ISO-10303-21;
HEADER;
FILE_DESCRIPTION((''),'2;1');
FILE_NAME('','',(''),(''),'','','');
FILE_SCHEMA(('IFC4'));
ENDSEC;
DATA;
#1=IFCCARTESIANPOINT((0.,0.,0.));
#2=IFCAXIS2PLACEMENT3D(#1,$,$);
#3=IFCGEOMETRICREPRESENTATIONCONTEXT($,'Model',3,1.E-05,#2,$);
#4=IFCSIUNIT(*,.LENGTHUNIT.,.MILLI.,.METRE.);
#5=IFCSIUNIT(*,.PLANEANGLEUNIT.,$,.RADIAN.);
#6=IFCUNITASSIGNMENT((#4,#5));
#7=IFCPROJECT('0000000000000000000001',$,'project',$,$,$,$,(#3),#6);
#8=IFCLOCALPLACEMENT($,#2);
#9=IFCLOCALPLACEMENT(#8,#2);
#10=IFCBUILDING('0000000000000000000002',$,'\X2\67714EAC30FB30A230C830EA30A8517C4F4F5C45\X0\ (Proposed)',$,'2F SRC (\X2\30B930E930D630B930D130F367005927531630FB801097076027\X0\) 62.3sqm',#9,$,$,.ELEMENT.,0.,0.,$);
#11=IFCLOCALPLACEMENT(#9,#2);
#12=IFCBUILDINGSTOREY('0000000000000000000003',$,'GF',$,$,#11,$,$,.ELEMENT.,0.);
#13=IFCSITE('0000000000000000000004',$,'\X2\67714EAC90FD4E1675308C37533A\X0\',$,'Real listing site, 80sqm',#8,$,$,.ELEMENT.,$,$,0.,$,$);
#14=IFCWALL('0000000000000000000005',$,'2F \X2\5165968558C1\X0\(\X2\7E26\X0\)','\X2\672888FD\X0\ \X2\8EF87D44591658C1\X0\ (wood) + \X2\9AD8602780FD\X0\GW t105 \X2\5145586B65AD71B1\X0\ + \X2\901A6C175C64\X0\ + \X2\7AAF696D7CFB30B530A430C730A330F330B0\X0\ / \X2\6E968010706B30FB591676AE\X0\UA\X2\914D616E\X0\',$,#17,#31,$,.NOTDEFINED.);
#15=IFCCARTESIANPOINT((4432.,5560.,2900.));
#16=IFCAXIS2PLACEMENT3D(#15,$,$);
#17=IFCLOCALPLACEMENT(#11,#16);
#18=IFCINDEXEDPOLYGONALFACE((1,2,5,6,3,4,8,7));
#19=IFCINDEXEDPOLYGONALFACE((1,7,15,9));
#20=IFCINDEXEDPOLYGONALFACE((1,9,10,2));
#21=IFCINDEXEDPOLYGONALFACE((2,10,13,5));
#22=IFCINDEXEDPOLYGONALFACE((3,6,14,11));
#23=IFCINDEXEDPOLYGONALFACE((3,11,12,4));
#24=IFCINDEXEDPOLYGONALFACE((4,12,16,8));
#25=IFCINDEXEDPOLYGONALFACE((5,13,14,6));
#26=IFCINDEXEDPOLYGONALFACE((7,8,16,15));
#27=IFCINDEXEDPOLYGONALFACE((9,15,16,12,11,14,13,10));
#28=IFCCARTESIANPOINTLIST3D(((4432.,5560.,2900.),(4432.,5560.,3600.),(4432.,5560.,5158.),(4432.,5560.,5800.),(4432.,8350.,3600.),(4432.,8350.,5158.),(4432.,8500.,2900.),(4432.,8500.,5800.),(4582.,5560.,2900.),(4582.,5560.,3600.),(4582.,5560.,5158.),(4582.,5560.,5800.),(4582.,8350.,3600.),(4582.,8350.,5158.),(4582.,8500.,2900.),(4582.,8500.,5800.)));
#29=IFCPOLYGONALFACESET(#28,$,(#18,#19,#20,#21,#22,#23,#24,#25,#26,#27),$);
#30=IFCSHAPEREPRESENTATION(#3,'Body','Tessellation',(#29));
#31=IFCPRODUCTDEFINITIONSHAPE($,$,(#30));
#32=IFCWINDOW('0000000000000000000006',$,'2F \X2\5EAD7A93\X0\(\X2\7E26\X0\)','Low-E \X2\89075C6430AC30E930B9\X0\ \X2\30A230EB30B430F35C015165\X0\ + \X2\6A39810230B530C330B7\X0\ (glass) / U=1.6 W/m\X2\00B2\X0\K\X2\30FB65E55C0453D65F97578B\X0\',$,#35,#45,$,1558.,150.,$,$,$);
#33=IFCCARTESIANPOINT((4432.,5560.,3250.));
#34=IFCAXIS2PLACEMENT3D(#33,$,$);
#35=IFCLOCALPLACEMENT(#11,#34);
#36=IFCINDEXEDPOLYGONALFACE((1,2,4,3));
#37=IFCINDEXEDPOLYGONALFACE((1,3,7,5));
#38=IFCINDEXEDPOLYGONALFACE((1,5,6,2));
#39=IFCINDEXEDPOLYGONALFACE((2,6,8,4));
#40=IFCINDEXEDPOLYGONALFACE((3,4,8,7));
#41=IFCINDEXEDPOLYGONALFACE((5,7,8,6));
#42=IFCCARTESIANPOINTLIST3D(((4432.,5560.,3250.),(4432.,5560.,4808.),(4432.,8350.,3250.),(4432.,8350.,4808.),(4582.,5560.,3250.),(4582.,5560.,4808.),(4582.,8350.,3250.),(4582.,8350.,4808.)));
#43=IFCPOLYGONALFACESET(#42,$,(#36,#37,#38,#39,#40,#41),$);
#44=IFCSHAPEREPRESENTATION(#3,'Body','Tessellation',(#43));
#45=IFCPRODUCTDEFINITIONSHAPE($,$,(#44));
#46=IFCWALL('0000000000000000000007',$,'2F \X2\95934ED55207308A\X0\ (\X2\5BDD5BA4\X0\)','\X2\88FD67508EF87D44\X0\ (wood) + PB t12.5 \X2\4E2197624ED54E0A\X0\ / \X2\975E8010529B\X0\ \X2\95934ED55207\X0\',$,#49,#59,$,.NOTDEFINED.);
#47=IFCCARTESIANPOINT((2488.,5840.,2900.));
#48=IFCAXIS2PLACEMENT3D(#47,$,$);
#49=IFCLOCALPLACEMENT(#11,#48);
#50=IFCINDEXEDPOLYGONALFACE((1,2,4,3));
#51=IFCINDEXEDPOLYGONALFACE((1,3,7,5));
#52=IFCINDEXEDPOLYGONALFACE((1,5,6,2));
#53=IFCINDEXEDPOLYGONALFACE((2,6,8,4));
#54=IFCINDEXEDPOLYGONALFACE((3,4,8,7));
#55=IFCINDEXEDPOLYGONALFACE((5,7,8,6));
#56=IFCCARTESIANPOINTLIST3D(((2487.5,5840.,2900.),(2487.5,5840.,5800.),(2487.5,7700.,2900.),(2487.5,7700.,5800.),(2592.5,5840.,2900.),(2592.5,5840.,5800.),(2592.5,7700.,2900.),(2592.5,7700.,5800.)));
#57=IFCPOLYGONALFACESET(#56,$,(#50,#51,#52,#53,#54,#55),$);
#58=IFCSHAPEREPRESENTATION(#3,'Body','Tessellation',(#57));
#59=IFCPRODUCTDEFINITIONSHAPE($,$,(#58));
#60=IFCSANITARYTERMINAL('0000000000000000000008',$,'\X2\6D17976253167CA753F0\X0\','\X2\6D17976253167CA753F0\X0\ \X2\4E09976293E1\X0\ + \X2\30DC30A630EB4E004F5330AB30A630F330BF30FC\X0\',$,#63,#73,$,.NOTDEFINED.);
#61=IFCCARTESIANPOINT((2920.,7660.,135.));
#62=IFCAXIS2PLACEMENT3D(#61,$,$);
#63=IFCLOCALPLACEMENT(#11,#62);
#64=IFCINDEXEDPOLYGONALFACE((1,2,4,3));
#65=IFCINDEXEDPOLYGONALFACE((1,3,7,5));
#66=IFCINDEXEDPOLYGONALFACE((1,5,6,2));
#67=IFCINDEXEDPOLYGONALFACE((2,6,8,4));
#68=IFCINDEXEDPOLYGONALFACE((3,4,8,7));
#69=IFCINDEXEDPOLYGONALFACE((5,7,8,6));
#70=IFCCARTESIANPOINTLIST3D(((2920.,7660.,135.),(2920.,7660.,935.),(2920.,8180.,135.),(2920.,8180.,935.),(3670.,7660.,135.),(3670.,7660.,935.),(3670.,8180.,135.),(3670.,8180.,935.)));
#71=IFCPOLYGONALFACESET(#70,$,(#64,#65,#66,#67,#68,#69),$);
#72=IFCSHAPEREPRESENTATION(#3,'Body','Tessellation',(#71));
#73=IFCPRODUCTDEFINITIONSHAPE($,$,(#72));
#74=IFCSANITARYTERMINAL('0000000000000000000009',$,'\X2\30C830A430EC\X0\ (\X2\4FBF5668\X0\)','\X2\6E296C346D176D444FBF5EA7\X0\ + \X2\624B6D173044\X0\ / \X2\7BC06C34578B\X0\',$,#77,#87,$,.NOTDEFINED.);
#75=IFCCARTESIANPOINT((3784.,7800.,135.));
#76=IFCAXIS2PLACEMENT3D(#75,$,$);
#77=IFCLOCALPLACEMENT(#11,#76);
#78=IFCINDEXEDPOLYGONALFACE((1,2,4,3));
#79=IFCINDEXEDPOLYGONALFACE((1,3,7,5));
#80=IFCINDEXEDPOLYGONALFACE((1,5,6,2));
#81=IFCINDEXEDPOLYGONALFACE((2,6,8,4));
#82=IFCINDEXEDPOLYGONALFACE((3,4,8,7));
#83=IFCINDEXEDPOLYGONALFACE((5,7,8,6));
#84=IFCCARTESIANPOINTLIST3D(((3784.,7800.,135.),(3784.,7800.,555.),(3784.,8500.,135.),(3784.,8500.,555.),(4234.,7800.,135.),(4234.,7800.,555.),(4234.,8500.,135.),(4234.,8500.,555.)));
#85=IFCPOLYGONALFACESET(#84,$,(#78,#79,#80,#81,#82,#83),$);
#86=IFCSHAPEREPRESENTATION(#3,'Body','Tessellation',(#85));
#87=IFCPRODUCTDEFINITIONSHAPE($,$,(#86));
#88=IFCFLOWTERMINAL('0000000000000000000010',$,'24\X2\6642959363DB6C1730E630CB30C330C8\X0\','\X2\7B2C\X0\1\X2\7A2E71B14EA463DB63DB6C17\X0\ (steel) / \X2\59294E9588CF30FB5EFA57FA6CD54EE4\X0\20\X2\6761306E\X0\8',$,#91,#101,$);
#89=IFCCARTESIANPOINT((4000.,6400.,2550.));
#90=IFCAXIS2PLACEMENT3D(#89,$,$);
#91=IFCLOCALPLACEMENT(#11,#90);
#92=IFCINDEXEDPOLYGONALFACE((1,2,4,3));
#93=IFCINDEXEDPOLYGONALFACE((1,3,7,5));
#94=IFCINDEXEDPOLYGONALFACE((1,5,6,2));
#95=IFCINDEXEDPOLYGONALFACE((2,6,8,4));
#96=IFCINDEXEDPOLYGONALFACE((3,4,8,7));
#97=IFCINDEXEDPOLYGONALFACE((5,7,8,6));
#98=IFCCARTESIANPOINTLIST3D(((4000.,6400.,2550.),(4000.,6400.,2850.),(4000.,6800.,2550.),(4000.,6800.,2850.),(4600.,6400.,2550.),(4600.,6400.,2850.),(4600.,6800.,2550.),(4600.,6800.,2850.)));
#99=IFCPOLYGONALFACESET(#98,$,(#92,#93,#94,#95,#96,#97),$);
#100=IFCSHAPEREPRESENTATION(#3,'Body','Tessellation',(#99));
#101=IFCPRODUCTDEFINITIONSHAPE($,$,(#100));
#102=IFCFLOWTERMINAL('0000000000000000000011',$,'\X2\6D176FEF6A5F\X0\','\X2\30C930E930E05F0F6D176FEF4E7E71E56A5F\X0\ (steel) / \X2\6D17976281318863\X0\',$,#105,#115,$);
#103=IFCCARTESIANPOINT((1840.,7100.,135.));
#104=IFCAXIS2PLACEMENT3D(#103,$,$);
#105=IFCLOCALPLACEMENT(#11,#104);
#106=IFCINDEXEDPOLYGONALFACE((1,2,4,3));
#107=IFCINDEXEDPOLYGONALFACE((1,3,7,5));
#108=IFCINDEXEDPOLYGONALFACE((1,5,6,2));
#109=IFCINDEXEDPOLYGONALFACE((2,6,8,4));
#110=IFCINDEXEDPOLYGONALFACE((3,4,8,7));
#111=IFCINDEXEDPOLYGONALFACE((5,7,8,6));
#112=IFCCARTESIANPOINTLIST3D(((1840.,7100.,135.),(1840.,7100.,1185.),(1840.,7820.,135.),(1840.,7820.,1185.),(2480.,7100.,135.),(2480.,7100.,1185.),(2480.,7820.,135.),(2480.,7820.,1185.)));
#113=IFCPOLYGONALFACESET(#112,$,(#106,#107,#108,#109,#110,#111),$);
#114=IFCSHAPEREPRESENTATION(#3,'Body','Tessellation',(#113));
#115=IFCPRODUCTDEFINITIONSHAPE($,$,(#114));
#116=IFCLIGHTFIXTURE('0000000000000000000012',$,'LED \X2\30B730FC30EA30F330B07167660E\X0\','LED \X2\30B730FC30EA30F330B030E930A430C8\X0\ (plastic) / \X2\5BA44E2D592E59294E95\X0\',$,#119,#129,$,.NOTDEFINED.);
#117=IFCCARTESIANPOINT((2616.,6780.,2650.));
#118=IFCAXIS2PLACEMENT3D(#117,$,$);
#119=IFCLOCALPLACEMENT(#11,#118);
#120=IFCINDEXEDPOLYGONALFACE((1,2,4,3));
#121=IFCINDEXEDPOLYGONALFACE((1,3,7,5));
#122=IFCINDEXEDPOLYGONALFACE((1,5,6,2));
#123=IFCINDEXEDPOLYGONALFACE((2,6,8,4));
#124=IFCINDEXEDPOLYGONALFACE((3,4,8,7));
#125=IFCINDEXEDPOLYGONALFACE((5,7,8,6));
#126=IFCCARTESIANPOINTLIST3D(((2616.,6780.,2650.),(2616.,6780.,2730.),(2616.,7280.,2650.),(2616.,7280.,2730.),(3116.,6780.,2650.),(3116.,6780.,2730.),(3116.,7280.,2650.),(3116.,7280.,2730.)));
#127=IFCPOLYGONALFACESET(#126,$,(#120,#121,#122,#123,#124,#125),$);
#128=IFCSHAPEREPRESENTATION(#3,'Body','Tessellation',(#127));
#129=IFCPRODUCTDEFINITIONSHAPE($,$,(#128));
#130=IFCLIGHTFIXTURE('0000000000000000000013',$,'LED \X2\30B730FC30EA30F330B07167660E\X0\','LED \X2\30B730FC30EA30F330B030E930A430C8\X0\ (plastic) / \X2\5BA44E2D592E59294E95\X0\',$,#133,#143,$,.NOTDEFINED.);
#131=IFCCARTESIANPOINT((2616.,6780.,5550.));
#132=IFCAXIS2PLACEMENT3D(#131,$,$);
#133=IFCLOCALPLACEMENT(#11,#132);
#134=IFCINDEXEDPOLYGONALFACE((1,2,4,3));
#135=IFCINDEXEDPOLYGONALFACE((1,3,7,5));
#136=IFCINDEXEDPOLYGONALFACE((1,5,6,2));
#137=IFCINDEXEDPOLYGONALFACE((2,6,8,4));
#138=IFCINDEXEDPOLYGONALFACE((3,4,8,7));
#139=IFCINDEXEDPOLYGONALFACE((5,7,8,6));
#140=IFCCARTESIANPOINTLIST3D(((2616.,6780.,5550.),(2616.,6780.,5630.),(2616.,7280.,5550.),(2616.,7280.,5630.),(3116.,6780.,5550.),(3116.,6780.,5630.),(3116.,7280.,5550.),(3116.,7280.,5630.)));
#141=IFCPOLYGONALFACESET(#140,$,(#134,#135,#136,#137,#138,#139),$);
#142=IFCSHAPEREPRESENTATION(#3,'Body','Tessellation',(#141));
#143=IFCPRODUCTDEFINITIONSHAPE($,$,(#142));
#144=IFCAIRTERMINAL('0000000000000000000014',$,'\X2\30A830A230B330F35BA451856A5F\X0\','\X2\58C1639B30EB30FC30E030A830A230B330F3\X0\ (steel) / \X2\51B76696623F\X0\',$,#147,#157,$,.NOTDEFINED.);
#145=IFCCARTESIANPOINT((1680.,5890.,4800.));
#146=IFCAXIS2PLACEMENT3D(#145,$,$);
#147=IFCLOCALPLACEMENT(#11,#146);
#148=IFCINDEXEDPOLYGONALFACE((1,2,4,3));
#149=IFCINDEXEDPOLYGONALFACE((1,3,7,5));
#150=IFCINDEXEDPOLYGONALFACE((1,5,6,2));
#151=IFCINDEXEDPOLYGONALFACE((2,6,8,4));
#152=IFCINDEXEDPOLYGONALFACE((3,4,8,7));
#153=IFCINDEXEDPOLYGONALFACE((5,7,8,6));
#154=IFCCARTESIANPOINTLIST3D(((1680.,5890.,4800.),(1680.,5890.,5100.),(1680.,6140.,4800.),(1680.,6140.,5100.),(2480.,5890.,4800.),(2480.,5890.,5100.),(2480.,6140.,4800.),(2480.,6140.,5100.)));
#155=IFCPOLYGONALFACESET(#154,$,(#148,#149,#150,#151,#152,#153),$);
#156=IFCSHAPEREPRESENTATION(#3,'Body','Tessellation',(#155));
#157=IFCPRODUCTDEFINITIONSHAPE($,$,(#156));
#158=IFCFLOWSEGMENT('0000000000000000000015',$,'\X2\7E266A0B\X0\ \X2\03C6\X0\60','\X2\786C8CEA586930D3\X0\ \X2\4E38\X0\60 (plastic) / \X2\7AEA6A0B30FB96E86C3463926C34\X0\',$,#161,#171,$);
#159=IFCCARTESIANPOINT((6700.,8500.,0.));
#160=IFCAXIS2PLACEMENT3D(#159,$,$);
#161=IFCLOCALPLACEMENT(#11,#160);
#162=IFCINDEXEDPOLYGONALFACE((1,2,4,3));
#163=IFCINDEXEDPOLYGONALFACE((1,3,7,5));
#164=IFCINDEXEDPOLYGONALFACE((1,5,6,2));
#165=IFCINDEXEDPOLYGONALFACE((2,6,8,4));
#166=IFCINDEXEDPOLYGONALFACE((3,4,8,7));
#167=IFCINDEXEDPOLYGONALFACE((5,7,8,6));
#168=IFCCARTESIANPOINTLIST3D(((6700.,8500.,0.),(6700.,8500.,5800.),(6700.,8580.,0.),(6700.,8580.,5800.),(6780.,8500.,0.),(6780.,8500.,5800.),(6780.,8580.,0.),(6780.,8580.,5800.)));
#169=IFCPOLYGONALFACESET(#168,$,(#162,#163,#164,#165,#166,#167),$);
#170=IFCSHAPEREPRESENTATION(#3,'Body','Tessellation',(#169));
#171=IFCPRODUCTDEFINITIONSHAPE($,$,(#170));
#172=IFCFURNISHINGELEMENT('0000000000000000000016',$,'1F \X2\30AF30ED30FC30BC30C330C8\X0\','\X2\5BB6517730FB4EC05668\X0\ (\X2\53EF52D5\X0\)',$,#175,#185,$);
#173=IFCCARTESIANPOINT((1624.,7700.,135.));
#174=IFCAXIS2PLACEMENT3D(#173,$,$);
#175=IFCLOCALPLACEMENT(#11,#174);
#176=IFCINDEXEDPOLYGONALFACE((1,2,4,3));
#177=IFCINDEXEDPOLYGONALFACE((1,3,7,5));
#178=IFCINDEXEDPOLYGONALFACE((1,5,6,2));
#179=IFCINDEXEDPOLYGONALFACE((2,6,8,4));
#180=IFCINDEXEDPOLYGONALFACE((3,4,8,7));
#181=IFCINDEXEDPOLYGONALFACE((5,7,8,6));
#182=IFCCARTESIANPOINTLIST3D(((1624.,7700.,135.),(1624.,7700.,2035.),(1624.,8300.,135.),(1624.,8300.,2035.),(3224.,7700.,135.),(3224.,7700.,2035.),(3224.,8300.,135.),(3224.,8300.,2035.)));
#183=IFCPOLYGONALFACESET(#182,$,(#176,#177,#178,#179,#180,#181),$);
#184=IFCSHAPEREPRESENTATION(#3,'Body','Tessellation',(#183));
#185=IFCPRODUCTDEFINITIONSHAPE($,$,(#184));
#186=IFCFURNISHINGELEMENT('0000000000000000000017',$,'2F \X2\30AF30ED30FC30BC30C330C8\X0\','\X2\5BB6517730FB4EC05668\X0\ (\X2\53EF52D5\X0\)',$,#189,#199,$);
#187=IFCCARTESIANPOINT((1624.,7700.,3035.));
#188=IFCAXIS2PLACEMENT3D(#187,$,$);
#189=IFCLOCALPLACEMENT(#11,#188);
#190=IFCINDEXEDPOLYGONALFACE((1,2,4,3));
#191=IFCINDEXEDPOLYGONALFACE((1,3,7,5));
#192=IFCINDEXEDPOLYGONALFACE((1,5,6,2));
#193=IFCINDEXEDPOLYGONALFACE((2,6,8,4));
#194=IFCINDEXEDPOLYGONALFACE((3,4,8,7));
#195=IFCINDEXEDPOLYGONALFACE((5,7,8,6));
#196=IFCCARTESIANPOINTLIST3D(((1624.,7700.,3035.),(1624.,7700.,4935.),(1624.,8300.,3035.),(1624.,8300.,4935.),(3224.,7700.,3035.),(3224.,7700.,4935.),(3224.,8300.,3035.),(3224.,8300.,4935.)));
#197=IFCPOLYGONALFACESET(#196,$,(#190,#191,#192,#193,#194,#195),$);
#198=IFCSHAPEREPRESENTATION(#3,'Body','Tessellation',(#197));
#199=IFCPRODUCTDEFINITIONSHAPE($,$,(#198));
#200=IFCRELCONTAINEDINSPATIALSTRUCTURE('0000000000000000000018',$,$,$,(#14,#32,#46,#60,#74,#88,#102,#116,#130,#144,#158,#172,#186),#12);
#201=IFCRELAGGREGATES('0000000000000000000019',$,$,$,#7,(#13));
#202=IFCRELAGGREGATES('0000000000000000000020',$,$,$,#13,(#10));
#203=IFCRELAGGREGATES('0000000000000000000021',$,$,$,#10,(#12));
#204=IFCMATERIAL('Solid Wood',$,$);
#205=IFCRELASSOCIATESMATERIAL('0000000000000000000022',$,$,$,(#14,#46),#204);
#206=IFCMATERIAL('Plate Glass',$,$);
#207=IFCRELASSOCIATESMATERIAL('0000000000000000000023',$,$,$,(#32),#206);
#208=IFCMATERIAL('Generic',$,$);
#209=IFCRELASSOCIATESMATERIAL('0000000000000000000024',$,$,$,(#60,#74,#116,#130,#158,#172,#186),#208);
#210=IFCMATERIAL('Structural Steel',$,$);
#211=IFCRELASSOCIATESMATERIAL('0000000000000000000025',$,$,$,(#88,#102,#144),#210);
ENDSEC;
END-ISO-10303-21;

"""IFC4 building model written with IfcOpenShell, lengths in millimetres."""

from ifc_helpers import new_model, si_unit, frame, frame_2d, origin, place, context, project, spatial, rectangle, extrude, material, element, fill, save


model = new_model("IFC4")

# Units and contexts
model_context = context("Model", 3, precision=1e-05, world=origin())
ifc_project = project(units=[si_unit("LENGTHUNIT", "METRE", prefix="MILLI"), si_unit("PLANEANGLEUNIT", "RADIAN")], contexts=[model_context])

# Site, building, storey
site_placement = place(None, origin())
site = spatial("IfcSite", under=ifc_project, at=site_placement, Name="東京都世田谷区", ObjectType="Real listing site, 80sqm", CompositionType="ELEMENT", RefElevation=0.0)
building_placement = place(site_placement, origin())
building = spatial("IfcBuilding", under=site, at=building_placement, Name="東京・アトリエ兼住居 (Proposed)", ObjectType="2F SRC (スラブスパン最大化・耐震性) 62.3sqm", CompositionType="ELEMENT", ElevationOfRefHeight=0.0, ElevationOfTerrain=0.0)
storey_placement = place(building_placement, origin())
storey = spatial("IfcBuildingStorey", under=building, at=storey_placement, Name="GF", CompositionType="ELEMENT", Elevation=0.0)

# Shared definitions
ifc_material_1 = material(Name="Solid Wood")

# Shared definitions
ifc_material_2 = material(Name="Plate Glass")

# Wall, opening, window
wall_1_placement = place(storey_placement, frame((4432.0, 5560.0, 2900.0)))
wall_1 = element("IfcWall", 1, at=wall_1_placement, inside=storey, material=ifc_material_1, Name="2F 入隅壁(縦)", Description="木製 軸組外壁 (wood) + 高性能GW t105 充填断熱 + 通気層 + 窯業系サイディング / 準耐火・外皮UA配慮", PredefinedType="NOTDEFINED", context=model_context, shape_type="SweptSolid", body=[
    extrude(rectangle(XDim=150.0, YDim=2940.0, at=frame_2d((75.0, 1470.0))), frame((4432.0, 5560.0, 2900.0)), (0.0, 0.0, 1.0), 2900.0),
])
opening_1_placement = place(storey_placement, frame((4432.0, 5560.0, 3250.0)))
opening_1 = element("IfcOpeningElement", 2, at=opening_1_placement, cuts=wall_1, PredefinedType="NOTDEFINED", context=model_context, shape_type="SweptSolid", body=[
    extrude(rectangle(XDim=150.0, YDim=2790.0, at=frame_2d((75.0, 1395.0))), frame((4432.0, 5560.0, 3250.0)), (0.0, 0.0, 1.0), 1558.0),
])
window_1_placement = place(storey_placement, frame((4432.0, 5560.0, 3250.0)))
window_1 = element("IfcWindow", 3, at=window_1_placement, inside=storey, material=ifc_material_2, Name="2F 庭窓(縦)", Description="Low-E 複層ガラス アルゴン封入 + 樹脂サッシ (glass) / U=1.6 W/m²K・日射取得型", OverallHeight=1558.0, OverallWidth=150.0, context=model_context, shape_type="SweptSolid", body=[
    extrude(rectangle(XDim=150.0, YDim=2790.0, at=frame_2d((75.0, 1395.0))), frame((4432.0, 5560.0, 3250.0)), (0.0, 0.0, 1.0), 1558.0),
])
fill(opening_1, window_1)

# Wall
wall_2_placement = place(storey_placement, frame((2488.0, 5840.0, 2900.0)))
element("IfcWall", 4, at=wall_2_placement, inside=storey, material=ifc_material_1, Name="2F 間仕切り (寝室)", Description="製材軸組 (wood) + PB t12.5 両面仕上 / 非耐力 間仕切", PredefinedType="NOTDEFINED", context=model_context, shape_type="SweptSolid", body=[
    extrude(rectangle(XDim=105.0, YDim=1860.0, at=frame_2d((52.0, 930.0))), frame((2488.0, 5840.0, 2900.0)), (0.0, 0.0, 1.0), 2900.0),
])

# Sanitary terminals
ifc_material_3 = material(Name="Generic")
sanitary_terminal_1_placement = place(storey_placement, frame((2920.0, 7660.0, 135.0)))
element("IfcSanitaryTerminal", 5, at=sanitary_terminal_1_placement, inside=storey, material=ifc_material_3, Name="洗面化粧台", Description="洗面化粧台 三面鏡 + ボウル一体カウンター", PredefinedType="NOTDEFINED", context=model_context, shape_type="SweptSolid", body=[
    extrude(rectangle(XDim=750.0, YDim=520.0, at=frame_2d((375.0, 260.0))), frame((2920.0, 7660.0, 135.0)), (0.0, 0.0, 1.0), 800.0),
])
sanitary_terminal_2_placement = place(storey_placement, frame((3784.0, 7800.0, 135.0)))
element("IfcSanitaryTerminal", 6, at=sanitary_terminal_2_placement, inside=storey, material=ifc_material_3, Name="トイレ (便器)", Description="温水洗浄便座 + 手洗い / 節水型", PredefinedType="NOTDEFINED", context=model_context, shape_type="SweptSolid", body=[
    extrude(rectangle(XDim=450.0, YDim=700.0, at=frame_2d((225.0, 350.0))), frame((3784.0, 7800.0, 135.0)), (0.0, 0.0, 1.0), 420.0),
])

# Flow terminals
ifc_material_4 = material(Name="Structural Steel")
flow_terminal_1_placement = place(storey_placement, frame((4000.0, 6400.0, 2550.0)))
element("IfcFlowTerminal", 7, at=flow_terminal_1_placement, inside=storey, material=ifc_material_4, Name="24時間換気ユニット", Description="第1種熱交換換気 (steel) / 天井裏・建基法令20条の8", context=model_context, shape_type="SweptSolid", body=[
    extrude(rectangle(XDim=600.0, YDim=400.0, at=frame_2d((300.0, 200.0))), frame((4000.0, 6400.0, 2550.0)), (0.0, 0.0, 1.0), 300.0),
])
flow_terminal_2_placement = place(storey_placement, frame((1840.0, 7100.0, 135.0)))
element("IfcFlowTerminal", 8, at=flow_terminal_2_placement, inside=storey, material=ifc_material_4, Name="洗濯機", Description="ドラム式洗濯乾燥機 (steel) / 洗面脱衣", context=model_context, shape_type="SweptSolid", body=[
    extrude(rectangle(XDim=640.0, YDim=720.0, at=frame_2d((320.0, 360.0))), frame((1840.0, 7100.0, 135.0)), (0.0, 0.0, 1.0), 1050.0),
])

# Light fixtures
light_fixture_1_placement = place(storey_placement, frame((2616.0, 6780.0, 2650.0)))
element("IfcLightFixture", 9, at=light_fixture_1_placement, inside=storey, material=ifc_material_3, Name="LED シーリング照明", Description="LED シーリングライト (plastic) / 室中央天井", PredefinedType="NOTDEFINED", context=model_context, shape_type="SweptSolid", body=[
    extrude(rectangle(XDim=500.0, YDim=500.0, at=frame_2d((250.0, 250.0))), frame((2616.0, 6780.0, 2650.0)), (0.0, 0.0, 1.0), 80.0),
])
light_fixture_2_placement = place(storey_placement, frame((2616.0, 6780.0, 5550.0)))
element("IfcLightFixture", 10, at=light_fixture_2_placement, inside=storey, material=ifc_material_3, Name="LED シーリング照明", Description="LED シーリングライト (plastic) / 室中央天井", PredefinedType="NOTDEFINED", context=model_context, shape_type="SweptSolid", body=[
    extrude(rectangle(XDim=500.0, YDim=500.0, at=frame_2d((250.0, 250.0))), frame((2616.0, 6780.0, 5550.0)), (0.0, 0.0, 1.0), 80.0),
])

# Air terminal
air_terminal_placement = place(storey_placement, frame((1680.0, 5890.0, 4800.0)))
element("IfcAirTerminal", 11, at=air_terminal_placement, inside=storey, material=ifc_material_4, Name="エアコン室内機", Description="壁掛ルームエアコン (steel) / 冷暖房", PredefinedType="NOTDEFINED", context=model_context, shape_type="SweptSolid", body=[
    extrude(rectangle(XDim=800.0, YDim=250.0, at=frame_2d((400.0, 125.0))), frame((1680.0, 5890.0, 4800.0)), (0.0, 0.0, 1.0), 300.0),
])

# Flow segment
flow_segment_placement = place(storey_placement, frame((6700.0, 8500.0, 0.0)))
element("IfcFlowSegment", 12, at=flow_segment_placement, inside=storey, material=ifc_material_3, Name="縦樋 φ60", Description="硬質塩ビ 丸60 (plastic) / 竪樋・雨水排水", context=model_context, shape_type="SweptSolid", body=[
    extrude(rectangle(XDim=80.0, YDim=80.0, at=frame_2d((40.0, 40.0))), frame((6700.0, 8500.0, 0.0)), (0.0, 0.0, 1.0), 5800.0),
])

# Furnishing elements
furnishing_1_placement = place(storey_placement, frame((1624.0, 7700.0, 135.0)))
element("IfcFurnishingElement", 13, at=furnishing_1_placement, inside=storey, material=ifc_material_3, Name="1F クローゼット", Description="家具・什器 (可動)", context=model_context, shape_type="SweptSolid", body=[
    extrude(rectangle(XDim=1600.0, YDim=600.0, at=frame_2d((800.0, 300.0))), frame((1624.0, 7700.0, 135.0)), (0.0, 0.0, 1.0), 1900.0),
])
furnishing_2_placement = place(storey_placement, frame((1624.0, 7700.0, 3035.0)))
element("IfcFurnishingElement", 14, at=furnishing_2_placement, inside=storey, material=ifc_material_3, Name="2F クローゼット", Description="家具・什器 (可動)", context=model_context, shape_type="SweptSolid", body=[
    extrude(rectangle(XDim=1600.0, YDim=600.0, at=frame_2d((800.0, 300.0))), frame((1624.0, 7700.0, 3035.0)), (0.0, 0.0, 1.0), 1900.0),
])

save(model, "model.ifc")
